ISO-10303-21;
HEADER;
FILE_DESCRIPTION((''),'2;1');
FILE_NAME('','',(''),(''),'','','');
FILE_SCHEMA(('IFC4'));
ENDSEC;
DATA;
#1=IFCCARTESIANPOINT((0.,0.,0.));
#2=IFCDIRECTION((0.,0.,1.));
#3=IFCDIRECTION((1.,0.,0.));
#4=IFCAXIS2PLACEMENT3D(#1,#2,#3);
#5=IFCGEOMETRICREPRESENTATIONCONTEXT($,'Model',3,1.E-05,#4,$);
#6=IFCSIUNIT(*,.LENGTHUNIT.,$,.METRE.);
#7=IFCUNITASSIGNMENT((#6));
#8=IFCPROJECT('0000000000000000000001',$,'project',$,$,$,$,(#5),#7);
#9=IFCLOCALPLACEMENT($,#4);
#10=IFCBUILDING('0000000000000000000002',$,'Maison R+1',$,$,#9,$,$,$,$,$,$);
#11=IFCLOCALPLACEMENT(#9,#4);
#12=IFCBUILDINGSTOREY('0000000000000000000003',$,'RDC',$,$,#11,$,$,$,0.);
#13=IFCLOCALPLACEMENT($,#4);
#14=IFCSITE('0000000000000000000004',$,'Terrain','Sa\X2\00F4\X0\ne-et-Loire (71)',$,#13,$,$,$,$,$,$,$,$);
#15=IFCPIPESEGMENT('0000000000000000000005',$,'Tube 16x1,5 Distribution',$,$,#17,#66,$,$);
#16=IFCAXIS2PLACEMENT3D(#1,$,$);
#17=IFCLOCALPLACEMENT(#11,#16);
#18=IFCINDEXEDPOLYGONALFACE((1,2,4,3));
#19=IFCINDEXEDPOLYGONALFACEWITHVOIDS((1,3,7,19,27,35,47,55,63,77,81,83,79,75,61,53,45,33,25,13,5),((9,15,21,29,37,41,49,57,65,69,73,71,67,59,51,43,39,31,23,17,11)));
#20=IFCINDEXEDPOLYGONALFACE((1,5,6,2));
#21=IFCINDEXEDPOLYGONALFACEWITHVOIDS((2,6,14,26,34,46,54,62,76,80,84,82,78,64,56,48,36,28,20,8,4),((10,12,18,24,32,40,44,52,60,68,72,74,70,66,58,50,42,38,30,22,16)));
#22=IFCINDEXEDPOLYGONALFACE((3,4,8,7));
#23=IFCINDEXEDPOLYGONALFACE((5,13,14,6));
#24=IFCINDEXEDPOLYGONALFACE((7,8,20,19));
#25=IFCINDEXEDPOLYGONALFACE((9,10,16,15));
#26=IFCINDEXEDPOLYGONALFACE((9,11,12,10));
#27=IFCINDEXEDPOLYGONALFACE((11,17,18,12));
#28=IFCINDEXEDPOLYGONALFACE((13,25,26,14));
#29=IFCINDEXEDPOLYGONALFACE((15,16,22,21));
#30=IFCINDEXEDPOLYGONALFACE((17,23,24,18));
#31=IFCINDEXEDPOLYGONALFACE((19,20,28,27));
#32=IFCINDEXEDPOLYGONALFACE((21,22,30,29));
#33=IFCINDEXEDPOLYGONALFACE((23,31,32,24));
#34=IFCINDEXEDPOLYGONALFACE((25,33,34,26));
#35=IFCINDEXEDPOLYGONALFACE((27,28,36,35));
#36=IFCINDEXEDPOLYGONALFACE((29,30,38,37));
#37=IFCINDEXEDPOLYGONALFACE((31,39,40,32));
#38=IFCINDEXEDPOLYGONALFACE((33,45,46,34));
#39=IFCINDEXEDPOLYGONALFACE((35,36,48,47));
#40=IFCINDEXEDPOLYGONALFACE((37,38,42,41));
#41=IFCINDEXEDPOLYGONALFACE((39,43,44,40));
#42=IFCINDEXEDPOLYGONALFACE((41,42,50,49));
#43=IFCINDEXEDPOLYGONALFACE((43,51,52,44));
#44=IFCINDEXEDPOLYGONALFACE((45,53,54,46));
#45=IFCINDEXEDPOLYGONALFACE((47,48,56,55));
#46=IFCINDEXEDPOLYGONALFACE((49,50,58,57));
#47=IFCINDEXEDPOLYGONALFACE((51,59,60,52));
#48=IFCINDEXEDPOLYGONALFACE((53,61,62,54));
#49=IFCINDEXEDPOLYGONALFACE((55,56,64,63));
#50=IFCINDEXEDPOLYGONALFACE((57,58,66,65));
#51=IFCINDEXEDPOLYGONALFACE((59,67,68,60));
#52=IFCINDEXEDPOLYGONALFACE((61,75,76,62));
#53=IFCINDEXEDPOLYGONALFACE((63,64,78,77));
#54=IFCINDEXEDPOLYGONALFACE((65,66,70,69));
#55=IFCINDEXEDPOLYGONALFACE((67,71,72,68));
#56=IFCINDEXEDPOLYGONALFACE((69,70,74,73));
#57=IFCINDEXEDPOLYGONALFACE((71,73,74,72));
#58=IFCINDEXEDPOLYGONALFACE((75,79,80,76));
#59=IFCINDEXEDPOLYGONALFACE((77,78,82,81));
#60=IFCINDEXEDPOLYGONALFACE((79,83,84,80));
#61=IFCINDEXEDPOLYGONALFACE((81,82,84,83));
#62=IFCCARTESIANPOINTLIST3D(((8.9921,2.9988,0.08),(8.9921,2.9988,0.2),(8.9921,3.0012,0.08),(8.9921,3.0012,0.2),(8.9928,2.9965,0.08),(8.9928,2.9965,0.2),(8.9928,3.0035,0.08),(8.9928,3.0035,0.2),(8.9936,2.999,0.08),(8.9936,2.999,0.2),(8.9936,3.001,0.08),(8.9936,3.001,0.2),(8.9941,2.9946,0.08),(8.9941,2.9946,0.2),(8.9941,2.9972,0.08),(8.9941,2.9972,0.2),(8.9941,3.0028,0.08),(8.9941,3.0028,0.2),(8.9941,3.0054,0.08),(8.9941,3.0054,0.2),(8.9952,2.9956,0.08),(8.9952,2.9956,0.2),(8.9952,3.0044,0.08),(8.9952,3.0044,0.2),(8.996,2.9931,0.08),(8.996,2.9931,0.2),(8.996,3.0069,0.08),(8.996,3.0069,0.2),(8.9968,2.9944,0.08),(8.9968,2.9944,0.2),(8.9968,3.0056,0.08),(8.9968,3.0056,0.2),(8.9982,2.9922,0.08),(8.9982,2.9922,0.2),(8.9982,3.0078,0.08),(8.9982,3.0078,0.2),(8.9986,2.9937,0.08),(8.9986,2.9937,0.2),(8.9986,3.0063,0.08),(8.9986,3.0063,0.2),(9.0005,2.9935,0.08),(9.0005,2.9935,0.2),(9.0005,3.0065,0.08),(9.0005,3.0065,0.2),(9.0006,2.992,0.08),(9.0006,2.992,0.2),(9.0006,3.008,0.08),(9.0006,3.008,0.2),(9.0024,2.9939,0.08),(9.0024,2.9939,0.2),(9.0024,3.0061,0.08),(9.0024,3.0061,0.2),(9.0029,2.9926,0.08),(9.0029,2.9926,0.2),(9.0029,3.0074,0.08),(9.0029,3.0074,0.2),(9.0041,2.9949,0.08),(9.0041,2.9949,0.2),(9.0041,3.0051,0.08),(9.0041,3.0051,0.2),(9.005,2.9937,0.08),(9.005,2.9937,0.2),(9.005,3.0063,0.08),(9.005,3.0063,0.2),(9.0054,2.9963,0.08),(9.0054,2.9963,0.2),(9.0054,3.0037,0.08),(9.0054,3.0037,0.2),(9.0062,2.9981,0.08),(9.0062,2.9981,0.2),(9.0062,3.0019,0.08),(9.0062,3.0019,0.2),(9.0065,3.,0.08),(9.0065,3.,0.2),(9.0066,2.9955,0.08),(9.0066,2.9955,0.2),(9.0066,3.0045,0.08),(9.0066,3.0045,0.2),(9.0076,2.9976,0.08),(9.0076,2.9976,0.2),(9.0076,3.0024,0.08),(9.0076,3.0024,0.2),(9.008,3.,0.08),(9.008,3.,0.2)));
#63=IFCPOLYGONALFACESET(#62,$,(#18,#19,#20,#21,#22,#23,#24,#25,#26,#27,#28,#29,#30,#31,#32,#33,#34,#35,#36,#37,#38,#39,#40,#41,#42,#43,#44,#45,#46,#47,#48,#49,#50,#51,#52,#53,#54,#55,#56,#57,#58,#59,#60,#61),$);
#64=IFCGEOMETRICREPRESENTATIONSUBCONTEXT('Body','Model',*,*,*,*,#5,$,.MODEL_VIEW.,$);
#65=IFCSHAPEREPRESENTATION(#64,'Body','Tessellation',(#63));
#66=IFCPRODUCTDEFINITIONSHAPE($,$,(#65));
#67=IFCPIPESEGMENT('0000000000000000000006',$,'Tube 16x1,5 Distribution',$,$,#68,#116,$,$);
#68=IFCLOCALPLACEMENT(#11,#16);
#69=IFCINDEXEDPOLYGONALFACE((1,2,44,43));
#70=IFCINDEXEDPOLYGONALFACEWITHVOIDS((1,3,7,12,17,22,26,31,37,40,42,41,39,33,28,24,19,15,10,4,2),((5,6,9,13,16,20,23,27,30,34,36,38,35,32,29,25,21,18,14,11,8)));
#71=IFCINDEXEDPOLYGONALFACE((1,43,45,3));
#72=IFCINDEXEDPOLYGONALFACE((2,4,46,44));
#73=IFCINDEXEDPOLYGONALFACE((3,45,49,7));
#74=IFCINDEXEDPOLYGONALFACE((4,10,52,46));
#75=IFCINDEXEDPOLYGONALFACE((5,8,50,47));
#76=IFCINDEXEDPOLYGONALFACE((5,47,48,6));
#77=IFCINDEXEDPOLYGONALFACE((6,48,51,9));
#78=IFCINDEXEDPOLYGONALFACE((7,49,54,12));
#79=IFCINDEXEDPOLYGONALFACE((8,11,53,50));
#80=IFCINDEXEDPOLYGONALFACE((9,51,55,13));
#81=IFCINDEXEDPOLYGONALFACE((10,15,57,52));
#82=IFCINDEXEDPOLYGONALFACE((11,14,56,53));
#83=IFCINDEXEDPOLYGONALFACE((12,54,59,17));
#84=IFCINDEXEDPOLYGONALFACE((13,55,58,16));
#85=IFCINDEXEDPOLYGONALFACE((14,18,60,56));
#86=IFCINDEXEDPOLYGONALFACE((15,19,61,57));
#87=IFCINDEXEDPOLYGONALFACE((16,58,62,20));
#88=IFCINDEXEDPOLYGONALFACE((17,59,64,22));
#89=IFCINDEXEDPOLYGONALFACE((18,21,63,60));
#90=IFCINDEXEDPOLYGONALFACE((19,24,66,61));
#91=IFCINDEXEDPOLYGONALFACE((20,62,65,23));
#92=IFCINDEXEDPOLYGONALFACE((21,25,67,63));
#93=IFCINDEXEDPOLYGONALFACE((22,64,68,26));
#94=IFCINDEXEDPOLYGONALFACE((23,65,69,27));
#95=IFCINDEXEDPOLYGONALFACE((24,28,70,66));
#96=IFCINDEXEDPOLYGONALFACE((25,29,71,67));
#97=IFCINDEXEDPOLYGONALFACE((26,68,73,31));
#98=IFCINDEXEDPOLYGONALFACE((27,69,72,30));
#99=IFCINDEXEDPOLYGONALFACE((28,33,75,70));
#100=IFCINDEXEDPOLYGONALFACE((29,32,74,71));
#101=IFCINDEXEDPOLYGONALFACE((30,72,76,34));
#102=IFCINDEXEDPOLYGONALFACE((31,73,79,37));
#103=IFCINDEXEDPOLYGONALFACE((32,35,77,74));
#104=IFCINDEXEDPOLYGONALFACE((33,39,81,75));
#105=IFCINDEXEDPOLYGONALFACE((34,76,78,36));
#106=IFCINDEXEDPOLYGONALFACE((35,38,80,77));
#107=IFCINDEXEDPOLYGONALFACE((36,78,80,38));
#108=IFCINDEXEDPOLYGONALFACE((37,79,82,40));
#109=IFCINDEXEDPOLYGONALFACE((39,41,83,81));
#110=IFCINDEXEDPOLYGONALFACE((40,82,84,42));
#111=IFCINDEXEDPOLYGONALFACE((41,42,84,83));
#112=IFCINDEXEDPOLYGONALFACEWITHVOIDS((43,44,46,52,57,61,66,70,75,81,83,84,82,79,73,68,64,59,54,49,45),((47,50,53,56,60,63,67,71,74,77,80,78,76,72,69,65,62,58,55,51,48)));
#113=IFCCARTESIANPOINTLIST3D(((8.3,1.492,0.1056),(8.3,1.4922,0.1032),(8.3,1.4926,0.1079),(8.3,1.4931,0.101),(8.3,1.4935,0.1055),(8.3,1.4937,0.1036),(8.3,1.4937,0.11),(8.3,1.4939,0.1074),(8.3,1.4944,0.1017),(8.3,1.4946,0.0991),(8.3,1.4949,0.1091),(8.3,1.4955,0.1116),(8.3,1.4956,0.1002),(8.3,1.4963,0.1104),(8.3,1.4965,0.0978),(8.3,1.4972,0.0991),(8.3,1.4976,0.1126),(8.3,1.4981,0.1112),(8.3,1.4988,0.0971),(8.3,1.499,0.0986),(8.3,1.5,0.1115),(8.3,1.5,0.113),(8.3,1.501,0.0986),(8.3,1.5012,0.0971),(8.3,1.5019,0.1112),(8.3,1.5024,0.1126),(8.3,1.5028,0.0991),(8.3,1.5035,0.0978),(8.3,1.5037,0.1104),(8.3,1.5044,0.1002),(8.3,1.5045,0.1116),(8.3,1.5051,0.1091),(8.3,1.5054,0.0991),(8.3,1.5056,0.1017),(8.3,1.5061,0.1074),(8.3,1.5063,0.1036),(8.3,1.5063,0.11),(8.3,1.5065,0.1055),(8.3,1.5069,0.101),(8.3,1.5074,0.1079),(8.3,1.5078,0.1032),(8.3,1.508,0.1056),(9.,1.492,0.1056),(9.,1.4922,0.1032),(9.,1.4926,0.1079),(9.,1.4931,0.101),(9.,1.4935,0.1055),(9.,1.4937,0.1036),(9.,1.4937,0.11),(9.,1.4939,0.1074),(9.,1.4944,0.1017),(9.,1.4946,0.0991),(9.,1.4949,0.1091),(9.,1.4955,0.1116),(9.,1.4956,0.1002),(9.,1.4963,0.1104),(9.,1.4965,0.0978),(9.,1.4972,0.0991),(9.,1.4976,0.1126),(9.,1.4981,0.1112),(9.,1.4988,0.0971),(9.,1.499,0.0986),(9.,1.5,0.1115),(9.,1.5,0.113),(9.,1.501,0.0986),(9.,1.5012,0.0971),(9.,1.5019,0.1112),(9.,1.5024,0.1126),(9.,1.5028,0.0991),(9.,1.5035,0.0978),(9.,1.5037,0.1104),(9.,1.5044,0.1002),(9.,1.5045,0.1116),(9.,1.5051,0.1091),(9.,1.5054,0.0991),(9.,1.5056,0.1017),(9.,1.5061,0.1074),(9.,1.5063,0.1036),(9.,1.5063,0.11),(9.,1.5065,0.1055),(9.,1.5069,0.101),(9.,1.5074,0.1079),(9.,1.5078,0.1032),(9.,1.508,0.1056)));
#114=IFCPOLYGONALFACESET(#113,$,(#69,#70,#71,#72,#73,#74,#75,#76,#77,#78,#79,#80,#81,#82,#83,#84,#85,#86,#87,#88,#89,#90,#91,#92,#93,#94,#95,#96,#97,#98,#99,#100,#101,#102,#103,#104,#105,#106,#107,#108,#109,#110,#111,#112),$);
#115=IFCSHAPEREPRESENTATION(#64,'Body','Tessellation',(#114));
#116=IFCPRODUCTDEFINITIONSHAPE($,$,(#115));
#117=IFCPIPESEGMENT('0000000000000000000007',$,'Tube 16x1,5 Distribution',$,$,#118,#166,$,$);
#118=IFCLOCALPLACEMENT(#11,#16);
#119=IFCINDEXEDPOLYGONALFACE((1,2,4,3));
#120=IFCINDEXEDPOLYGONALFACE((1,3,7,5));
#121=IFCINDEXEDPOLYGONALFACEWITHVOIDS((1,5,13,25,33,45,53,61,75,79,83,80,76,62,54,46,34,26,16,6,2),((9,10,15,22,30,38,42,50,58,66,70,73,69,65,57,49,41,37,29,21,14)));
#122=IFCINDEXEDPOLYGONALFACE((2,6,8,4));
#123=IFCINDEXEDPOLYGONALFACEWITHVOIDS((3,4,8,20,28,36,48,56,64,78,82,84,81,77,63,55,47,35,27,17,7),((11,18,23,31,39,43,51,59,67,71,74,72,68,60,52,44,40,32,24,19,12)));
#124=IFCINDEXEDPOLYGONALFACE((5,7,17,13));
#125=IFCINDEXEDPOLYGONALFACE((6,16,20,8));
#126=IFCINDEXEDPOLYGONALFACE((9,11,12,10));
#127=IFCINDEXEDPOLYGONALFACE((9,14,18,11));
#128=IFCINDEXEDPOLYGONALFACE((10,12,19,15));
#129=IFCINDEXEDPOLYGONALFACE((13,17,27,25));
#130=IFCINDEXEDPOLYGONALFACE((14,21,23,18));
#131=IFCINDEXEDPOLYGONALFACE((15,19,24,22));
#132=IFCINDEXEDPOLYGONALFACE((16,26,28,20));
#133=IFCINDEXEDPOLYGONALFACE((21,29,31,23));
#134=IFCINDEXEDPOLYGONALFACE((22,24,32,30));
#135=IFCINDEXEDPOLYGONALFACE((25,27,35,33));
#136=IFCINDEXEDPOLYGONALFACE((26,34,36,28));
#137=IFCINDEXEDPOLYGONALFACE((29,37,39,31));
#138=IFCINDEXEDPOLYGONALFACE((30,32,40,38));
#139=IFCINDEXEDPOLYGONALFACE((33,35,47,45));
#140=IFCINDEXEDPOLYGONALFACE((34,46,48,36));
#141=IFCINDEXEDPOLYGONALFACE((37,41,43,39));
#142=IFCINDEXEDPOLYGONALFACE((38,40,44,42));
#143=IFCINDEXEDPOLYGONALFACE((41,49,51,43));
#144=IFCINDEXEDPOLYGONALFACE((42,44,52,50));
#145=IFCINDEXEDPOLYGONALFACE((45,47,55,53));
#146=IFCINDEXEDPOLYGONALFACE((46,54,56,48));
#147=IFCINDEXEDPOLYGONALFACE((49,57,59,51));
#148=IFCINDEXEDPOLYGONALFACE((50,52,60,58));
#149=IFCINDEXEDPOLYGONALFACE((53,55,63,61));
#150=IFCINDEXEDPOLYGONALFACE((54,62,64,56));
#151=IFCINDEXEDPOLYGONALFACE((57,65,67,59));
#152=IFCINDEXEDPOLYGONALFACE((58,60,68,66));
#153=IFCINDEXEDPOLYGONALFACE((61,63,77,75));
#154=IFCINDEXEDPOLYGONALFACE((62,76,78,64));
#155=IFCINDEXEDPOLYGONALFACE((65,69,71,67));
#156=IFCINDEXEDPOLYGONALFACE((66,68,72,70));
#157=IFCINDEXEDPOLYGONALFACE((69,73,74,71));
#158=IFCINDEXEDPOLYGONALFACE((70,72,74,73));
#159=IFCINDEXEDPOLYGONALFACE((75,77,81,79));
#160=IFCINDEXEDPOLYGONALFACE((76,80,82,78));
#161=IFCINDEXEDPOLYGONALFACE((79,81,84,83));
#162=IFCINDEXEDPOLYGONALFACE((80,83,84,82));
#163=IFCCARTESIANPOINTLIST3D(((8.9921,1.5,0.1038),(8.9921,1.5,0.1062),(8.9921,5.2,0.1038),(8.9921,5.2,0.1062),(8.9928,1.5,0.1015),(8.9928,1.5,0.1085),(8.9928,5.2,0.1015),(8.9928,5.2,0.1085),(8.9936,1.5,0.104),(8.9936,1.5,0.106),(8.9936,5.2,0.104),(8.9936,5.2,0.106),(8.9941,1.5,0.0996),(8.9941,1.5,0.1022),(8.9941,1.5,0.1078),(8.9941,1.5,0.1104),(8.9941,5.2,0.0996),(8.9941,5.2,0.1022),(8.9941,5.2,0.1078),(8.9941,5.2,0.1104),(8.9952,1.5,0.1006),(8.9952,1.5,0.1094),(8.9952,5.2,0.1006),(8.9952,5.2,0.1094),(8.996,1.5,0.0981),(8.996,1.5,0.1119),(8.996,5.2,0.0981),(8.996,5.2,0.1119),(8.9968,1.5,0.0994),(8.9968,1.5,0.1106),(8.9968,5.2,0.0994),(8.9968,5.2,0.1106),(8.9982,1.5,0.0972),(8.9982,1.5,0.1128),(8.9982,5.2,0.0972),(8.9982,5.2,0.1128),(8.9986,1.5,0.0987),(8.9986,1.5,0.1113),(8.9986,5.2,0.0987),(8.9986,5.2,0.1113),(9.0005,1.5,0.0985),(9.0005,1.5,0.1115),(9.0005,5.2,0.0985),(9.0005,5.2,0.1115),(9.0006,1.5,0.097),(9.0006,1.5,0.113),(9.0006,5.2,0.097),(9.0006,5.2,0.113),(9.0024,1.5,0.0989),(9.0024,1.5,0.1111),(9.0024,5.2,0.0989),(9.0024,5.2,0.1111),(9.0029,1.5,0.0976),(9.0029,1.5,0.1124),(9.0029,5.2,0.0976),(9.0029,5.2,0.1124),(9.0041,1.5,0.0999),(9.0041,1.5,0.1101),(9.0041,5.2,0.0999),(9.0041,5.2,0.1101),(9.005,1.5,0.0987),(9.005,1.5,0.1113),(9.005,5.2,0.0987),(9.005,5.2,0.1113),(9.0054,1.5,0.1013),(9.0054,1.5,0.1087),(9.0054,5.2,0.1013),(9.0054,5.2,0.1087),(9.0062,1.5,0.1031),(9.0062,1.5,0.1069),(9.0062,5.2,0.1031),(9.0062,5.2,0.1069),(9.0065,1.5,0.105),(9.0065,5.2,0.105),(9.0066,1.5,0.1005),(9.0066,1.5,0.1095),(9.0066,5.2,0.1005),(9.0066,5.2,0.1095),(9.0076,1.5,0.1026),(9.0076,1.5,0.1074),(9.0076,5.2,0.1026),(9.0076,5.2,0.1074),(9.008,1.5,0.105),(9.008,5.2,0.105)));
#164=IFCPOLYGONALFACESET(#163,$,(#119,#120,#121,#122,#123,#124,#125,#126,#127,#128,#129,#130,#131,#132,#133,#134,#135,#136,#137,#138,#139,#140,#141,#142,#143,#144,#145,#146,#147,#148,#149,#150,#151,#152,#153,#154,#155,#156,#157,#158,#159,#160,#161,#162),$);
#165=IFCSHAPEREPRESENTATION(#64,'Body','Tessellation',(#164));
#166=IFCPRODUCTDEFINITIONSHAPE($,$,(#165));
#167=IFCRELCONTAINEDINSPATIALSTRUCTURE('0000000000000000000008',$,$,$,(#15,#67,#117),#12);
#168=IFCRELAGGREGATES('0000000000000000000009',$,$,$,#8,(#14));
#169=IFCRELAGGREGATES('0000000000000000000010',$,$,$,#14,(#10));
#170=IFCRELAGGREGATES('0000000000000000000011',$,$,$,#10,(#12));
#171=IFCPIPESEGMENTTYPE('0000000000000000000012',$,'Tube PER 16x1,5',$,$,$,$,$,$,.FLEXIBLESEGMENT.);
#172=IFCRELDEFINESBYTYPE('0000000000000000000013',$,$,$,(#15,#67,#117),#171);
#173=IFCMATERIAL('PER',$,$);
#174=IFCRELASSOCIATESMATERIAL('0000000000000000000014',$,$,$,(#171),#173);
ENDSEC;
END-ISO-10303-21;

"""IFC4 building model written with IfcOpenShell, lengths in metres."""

from ifc_helpers import new_model, si_unit, frame, origin_with_axes, place, context, subcontext, project, spatial, hollow_circle, extrude, material, type_object, element, save


model = new_model("IFC4")

# Units and contexts
model_context = context("Model", 3, precision=1e-05, world=origin_with_axes())
body_context = subcontext(model_context, "Body", "Model", "MODEL_VIEW")
ifc_project = project(units=[si_unit("LENGTHUNIT", "METRE")], contexts=[model_context])

# Site, building, storey
site_placement = place(None, origin_with_axes())
site = spatial("IfcSite", under=ifc_project, at=site_placement, Name="Terrain", Description="Saône-et-Loire (71)")
building_placement = place(None, origin_with_axes())
building = spatial("IfcBuilding", under=site, at=building_placement, Name="Maison R+1")
storey_placement = place(building_placement, origin_with_axes())
storey = spatial("IfcBuildingStorey", under=building, at=storey_placement, Name="RDC", Elevation=0.0)

# Pipe segments
ifc_material_1 = material(Name="PER")
pipe_segment_type_1 = type_object("IfcPipeSegmentType", Name="Tube PER 16x1,5", PredefinedType="FLEXIBLESEGMENT", material=ifc_material_1)
pipe_segment_1_placement = place(storey_placement, frame((9.0, 3.0, 0.08), z_axis=(0.0, 0.0, 1.0), x_axis=(1.0, 0.0, 0.0)))
element("IfcPipeSegment", 1, at=pipe_segment_1_placement, inside=storey, type_object=pipe_segment_type_1, Name="Tube 16x1,5 Distribution", context=body_context, shape_type="SweptSolid", body=[
    extrude(hollow_circle(Radius=0.008, WallThickness=0.0015), origin_with_axes(), (0.0, 0.0, 1.0), 0.12),
])
pipe_segment_2_placement = place(storey_placement, frame((8.3, 1.5, 0.105), z_axis=(1.0, 0.0, 0.0), x_axis=(0.0, 0.0, 1.0)))
element("IfcPipeSegment", 2, at=pipe_segment_2_placement, inside=storey, type_object=pipe_segment_type_1, Name="Tube 16x1,5 Distribution", context=body_context, shape_type="SweptSolid", body=[
    extrude(hollow_circle(Radius=0.008, WallThickness=0.0015), origin_with_axes(), (0.0, 0.0, 1.0), 0.7),
])
pipe_segment_3_placement = place(storey_placement, frame((9.0, 1.5, 0.105), z_axis=(0.0, 1.0, 0.0), x_axis=(1.0, 0.0, 0.0)))
element("IfcPipeSegment", 3, at=pipe_segment_3_placement, inside=storey, type_object=pipe_segment_type_1, Name="Tube 16x1,5 Distribution", context=body_context, shape_type="SweptSolid", body=[
    extrude(hollow_circle(Radius=0.008, WallThickness=0.0015), origin_with_axes(), (0.0, 0.0, 1.0), 3.7),
])

save(model, "model.ifc")
